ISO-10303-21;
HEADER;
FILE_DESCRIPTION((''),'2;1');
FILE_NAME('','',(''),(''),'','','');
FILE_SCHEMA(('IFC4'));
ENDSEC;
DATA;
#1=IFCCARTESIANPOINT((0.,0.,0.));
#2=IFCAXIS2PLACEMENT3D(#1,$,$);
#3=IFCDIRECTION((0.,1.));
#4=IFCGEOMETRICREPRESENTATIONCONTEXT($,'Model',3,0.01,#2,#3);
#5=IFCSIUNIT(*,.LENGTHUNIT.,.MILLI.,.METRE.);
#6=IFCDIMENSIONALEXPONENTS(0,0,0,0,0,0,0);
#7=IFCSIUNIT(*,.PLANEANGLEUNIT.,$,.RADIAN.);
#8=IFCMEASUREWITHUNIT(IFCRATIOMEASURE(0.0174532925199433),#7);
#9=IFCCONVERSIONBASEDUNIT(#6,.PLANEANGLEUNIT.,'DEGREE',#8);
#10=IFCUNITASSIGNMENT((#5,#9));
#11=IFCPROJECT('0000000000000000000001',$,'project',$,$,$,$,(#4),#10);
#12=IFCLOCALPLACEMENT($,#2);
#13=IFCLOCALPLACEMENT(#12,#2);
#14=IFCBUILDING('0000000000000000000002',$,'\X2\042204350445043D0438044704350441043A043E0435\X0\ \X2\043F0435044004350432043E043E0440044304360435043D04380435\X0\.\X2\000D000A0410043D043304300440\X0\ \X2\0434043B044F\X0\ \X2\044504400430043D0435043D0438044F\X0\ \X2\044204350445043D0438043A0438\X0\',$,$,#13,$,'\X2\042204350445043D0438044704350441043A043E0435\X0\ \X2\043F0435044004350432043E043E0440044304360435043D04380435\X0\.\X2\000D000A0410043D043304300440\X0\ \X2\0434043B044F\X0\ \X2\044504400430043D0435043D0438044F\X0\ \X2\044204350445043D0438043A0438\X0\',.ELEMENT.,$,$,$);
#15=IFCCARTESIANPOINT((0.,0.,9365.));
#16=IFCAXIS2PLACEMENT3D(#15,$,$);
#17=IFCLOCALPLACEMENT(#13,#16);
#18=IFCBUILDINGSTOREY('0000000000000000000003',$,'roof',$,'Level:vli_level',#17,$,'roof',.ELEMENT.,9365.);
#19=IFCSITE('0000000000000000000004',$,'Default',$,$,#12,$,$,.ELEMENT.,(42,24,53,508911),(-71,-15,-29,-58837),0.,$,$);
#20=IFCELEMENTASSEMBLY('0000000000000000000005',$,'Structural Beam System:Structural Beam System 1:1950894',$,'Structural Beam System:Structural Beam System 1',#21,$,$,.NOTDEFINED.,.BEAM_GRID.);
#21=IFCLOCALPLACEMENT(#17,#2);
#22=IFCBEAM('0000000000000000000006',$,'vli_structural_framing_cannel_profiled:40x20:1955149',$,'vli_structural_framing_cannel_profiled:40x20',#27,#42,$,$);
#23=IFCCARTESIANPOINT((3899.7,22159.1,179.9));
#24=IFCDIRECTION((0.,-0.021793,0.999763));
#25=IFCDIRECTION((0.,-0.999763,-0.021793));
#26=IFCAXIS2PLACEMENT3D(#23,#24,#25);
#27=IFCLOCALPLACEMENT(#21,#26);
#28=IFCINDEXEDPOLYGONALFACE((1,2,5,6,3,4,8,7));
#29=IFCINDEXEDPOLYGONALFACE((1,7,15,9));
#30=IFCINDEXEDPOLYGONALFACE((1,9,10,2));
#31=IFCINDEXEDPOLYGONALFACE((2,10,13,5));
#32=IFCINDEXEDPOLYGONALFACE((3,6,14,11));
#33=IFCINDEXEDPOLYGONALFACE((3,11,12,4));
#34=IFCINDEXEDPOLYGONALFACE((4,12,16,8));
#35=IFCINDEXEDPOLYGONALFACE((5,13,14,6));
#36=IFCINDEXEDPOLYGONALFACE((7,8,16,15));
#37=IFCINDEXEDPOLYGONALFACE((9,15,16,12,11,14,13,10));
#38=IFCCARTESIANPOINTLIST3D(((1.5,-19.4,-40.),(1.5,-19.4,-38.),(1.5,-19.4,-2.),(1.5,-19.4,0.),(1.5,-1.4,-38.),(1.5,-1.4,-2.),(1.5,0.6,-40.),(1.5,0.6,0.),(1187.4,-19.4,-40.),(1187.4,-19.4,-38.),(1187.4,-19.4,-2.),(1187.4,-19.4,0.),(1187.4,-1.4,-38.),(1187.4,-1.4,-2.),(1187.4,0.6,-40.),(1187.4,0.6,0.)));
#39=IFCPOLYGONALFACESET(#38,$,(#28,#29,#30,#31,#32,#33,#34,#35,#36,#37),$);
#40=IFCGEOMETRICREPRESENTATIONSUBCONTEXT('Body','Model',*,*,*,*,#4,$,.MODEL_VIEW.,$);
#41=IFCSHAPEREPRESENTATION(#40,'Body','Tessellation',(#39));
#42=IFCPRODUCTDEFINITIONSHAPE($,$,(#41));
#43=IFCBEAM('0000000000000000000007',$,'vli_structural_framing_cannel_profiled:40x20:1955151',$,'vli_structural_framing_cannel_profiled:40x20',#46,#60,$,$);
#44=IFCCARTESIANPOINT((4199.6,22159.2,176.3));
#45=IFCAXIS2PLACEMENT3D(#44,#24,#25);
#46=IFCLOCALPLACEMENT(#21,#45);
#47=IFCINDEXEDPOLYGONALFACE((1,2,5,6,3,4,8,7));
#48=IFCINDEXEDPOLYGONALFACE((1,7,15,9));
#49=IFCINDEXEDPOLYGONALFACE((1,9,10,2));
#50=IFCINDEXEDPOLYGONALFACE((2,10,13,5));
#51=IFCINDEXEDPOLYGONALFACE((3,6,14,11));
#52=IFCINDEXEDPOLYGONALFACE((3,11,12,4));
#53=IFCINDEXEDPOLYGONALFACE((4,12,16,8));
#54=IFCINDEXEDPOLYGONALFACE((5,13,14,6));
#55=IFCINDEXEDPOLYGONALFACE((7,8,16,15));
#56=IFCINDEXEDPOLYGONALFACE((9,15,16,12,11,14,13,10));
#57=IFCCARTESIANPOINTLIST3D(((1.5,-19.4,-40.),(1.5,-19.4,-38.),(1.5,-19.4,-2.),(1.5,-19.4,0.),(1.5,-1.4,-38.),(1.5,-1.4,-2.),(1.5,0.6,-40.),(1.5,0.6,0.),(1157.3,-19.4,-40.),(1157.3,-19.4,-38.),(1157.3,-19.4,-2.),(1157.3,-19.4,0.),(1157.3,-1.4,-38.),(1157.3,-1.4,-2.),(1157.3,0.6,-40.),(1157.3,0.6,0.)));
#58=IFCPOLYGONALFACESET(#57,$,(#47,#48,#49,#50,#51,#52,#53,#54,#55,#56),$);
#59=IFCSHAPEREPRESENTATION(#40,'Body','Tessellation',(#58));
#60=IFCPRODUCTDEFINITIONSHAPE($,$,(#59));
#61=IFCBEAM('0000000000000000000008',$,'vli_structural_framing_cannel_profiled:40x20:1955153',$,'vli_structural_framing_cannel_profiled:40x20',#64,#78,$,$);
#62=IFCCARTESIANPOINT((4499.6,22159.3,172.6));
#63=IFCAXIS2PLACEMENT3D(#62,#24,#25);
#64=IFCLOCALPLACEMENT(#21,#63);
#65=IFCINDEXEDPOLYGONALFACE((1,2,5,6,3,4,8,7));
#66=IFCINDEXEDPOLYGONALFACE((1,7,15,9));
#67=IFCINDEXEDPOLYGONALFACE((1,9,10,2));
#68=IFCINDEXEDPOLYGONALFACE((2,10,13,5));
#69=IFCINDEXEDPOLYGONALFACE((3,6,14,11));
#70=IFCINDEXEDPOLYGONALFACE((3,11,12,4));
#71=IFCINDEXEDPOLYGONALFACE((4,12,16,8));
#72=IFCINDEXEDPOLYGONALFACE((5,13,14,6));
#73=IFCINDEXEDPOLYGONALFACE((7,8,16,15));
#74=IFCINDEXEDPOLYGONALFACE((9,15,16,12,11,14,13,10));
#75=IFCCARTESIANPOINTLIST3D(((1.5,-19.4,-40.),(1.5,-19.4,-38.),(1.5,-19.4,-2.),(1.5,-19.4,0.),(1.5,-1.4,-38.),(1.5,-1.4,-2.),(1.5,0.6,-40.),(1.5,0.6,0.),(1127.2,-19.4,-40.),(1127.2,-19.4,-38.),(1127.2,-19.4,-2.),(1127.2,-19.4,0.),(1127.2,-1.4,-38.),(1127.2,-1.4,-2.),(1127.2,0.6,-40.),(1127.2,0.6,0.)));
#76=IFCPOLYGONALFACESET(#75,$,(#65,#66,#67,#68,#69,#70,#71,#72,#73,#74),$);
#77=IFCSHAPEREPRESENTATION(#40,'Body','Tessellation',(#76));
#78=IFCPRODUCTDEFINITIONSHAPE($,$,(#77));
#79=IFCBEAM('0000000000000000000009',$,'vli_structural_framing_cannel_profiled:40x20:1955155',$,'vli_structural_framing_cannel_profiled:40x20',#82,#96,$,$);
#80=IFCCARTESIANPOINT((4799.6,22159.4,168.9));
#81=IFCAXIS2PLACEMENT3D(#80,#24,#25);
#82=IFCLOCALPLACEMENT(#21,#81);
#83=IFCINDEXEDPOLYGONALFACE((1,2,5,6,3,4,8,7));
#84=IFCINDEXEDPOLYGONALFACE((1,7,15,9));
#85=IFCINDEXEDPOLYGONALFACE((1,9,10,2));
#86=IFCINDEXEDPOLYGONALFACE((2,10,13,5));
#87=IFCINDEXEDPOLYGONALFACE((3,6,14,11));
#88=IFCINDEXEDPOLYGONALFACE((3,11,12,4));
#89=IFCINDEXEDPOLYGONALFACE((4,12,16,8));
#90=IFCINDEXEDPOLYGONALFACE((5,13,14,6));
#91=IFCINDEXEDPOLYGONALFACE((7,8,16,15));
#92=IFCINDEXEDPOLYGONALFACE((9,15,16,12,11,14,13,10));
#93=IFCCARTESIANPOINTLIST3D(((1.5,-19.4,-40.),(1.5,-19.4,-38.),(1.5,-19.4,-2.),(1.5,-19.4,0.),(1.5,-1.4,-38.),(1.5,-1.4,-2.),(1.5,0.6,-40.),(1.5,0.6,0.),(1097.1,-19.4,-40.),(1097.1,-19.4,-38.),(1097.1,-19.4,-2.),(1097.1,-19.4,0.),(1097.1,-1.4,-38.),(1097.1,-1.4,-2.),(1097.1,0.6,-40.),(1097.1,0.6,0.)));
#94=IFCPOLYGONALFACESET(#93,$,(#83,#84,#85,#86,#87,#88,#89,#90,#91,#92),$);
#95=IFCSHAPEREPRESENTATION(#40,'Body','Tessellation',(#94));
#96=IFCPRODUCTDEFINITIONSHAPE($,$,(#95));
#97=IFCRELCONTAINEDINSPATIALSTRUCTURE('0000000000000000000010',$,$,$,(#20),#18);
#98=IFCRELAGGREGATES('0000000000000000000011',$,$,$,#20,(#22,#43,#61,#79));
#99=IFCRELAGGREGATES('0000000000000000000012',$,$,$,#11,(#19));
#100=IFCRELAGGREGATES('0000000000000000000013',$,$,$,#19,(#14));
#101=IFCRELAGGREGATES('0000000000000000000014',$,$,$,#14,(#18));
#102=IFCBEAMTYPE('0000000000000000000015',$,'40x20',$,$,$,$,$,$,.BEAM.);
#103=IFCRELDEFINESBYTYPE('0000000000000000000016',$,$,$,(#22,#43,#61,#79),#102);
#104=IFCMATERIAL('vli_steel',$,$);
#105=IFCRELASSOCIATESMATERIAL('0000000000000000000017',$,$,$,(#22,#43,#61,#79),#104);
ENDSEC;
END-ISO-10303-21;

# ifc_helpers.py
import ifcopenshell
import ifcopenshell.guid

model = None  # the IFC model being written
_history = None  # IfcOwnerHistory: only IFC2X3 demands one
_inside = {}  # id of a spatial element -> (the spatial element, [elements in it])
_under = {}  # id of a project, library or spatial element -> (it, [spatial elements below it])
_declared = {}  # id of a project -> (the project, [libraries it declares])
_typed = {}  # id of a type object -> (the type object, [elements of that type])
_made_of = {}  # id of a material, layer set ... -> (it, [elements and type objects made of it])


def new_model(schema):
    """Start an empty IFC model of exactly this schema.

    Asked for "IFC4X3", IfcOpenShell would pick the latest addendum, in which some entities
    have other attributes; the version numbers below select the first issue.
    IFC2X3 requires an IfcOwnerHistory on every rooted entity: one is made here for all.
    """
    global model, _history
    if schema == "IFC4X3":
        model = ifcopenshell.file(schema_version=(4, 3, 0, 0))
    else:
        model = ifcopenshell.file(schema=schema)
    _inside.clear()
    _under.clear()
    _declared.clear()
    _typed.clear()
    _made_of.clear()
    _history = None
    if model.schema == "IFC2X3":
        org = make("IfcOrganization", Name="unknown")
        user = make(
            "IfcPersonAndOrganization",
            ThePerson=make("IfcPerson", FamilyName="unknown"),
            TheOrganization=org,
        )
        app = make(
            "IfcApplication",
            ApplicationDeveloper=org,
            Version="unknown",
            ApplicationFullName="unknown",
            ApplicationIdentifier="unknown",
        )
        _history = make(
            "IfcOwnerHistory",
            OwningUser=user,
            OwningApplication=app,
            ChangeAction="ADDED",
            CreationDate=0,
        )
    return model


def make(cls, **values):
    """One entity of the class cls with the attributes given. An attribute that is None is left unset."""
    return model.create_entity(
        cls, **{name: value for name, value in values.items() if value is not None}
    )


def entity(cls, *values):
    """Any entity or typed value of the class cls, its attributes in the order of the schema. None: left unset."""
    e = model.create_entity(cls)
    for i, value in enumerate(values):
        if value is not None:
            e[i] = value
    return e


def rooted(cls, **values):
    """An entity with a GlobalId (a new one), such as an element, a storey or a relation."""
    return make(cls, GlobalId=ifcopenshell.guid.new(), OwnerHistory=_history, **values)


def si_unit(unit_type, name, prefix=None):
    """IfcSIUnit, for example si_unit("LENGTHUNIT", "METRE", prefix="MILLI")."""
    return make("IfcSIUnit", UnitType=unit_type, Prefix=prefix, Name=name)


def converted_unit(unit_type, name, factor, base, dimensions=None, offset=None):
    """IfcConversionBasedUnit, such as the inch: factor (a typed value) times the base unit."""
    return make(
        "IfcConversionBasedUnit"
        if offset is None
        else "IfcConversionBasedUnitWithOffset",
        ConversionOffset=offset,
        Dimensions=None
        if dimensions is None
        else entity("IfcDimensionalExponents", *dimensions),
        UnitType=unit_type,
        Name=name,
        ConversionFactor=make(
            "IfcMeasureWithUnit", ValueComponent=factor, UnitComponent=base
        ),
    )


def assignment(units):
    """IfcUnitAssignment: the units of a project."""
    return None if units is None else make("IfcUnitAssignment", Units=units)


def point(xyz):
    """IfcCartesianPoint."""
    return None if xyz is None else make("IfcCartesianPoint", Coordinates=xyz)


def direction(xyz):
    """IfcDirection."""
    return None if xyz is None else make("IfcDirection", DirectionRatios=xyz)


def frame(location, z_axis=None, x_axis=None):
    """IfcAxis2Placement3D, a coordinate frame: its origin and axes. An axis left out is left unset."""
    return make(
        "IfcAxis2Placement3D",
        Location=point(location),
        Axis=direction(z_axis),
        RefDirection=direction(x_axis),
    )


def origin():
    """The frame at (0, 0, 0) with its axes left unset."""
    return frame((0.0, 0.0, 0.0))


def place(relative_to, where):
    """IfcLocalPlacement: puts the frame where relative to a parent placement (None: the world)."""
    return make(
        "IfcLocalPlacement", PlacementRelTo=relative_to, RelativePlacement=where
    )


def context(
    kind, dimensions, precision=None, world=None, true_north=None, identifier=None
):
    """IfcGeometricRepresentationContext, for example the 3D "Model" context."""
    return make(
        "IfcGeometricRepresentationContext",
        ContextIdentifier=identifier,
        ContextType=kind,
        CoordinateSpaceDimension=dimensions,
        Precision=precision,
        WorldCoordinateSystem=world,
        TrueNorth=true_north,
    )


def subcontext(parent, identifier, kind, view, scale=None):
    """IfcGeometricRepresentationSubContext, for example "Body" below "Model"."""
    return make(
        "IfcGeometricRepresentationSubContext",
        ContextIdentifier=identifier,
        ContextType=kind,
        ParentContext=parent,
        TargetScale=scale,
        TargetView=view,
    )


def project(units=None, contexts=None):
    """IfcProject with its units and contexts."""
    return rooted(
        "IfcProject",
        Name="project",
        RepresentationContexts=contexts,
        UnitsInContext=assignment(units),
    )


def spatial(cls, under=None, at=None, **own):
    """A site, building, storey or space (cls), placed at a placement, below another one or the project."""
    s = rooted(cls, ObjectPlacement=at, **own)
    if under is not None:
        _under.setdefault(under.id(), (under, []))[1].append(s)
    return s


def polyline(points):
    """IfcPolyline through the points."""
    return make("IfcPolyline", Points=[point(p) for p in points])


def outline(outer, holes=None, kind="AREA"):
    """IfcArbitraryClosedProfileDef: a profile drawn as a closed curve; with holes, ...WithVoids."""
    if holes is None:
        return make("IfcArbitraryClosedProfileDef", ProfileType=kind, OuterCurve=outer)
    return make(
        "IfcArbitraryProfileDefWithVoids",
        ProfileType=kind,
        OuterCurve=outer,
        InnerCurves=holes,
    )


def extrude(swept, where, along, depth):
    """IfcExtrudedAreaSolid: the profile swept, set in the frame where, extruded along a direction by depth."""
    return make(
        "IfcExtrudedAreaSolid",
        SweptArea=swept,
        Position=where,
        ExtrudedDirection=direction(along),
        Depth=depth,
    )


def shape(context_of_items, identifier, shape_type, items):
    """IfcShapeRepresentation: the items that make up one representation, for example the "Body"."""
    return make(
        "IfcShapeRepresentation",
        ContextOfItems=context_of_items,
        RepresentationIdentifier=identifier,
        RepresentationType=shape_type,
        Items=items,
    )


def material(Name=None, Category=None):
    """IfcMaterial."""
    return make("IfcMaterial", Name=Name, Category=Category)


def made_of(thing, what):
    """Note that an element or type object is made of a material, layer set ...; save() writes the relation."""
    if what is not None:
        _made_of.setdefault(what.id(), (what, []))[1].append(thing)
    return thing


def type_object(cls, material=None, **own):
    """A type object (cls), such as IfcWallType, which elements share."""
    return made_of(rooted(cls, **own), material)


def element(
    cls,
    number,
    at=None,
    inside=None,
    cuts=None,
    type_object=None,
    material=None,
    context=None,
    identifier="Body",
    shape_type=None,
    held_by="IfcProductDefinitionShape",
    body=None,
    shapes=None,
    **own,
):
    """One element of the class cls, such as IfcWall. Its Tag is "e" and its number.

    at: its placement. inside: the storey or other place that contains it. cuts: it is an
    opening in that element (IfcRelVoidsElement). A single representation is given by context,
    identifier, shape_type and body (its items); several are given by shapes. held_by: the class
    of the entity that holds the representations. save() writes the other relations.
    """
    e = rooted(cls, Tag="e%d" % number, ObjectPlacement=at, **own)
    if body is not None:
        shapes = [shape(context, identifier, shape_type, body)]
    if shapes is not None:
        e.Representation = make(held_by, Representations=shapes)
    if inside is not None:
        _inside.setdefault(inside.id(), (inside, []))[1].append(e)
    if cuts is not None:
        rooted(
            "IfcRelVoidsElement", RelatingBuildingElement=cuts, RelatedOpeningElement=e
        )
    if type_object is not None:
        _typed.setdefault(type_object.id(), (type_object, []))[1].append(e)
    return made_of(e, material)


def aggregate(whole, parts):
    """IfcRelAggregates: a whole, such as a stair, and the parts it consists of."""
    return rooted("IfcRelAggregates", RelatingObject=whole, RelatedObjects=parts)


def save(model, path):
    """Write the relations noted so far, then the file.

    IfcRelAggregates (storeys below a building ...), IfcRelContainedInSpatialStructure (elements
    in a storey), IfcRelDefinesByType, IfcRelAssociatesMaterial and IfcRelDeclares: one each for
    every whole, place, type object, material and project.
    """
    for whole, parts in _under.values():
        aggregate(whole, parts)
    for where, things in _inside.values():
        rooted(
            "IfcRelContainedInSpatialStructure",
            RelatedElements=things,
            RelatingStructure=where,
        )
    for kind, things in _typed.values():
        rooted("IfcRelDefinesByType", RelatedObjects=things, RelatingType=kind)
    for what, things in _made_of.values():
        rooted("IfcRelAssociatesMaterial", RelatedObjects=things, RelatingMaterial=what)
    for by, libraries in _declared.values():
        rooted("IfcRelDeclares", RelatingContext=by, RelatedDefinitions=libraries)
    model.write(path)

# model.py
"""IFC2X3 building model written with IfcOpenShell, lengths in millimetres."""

from ifc_helpers import new_model, entity, si_unit, converted_unit, direction, frame, origin, place, context, subcontext, project, spatial, polyline, outline, extrude, material, type_object, element, aggregate, save


model = new_model("IFC2X3")

# Units and contexts
model_context = context("Model", 3, precision=0.01, world=origin(), true_north=direction((0.0, 1.0)))
body_context = subcontext(model_context, "Body", "Model", "MODEL_VIEW")
ifc_project = project(units=[si_unit("LENGTHUNIT", "METRE", prefix="MILLI"), converted_unit("PLANEANGLEUNIT", "DEGREE", entity("IfcRatioMeasure", 0.0174532925199433), si_unit("PLANEANGLEUNIT", "RADIAN"), dimensions=[0, 0, 0, 0, 0, 0, 0])], contexts=[model_context])

# Site, building, storey
site_placement = place(None, origin())
site = spatial("IfcSite", under=ifc_project, at=site_placement, Name="Default", CompositionType="ELEMENT", RefLatitude=(42, 24, 53, 508911), RefLongitude=(-71, -15, -29, -58837), RefElevation=0.0)
building_placement = place(site_placement, origin())
building = spatial("IfcBuilding", under=site, at=building_placement, Name="Техническое перевооружение.\r\nАнгар для хранения техники", LongName="Техническое перевооружение.\r\nАнгар для хранения техники", CompositionType="ELEMENT")
storey_placement = place(building_placement, frame((0.0, 0.0, 9365.0)))
storey = spatial("IfcBuildingStorey", under=building, at=storey_placement, Name="roof", ObjectType="Level:vli_level", LongName="roof", CompositionType="ELEMENT", Elevation=9365.0)

# Element assembly, beams
ifc_material = material(Name="vli_steel")
beam_type = type_object("IfcBeamType", Name="40x20", PredefinedType="BEAM")
assembly_1_placement = place(storey_placement, origin())
assembly_1 = element("IfcElementAssembly", 1, at=assembly_1_placement, inside=storey, Name="Structural Beam System:Structural Beam System 1:1950894", ObjectType="Structural Beam System:Structural Beam System 1", AssemblyPlace="NOTDEFINED", PredefinedType="BEAM_GRID")
beam_1_placement = place(assembly_1_placement, frame((3899.7, 22159.1, 179.9), z_axis=(0.0, -0.021793, 0.999763), x_axis=(0.0, -0.999763, -0.021793)))
beam_1 = element("IfcBeam", 2, at=beam_1_placement, type_object=beam_type, material=ifc_material, Name="vli_structural_framing_cannel_profiled:40x20:1955149", ObjectType="vli_structural_framing_cannel_profiled:40x20", context=body_context, shape_type="SweptSolid", body=[
    extrude(outline(polyline([(-20.0, -9.5), (-18.0, -9.5), (-18.0, 8.5), (18.0, 8.5), (18.0, -9.5), (20.0, -9.5), (20.0, 10.5), (-20.0, 10.5), (-20.0, -9.5)])), frame((1.5, -9.9, -20.0), z_axis=(1.0, 0.0, 0.0), x_axis=(0.0, 0.0, -1.0)), (0.0, 0.0, 1.0), 1185.9),
])
beam_2_placement = place(assembly_1_placement, frame((4199.6, 22159.2, 176.3), z_axis=(0.0, -0.021793, 0.999763), x_axis=(0.0, -0.999763, -0.021793)))
beam_2 = element("IfcBeam", 3, at=beam_2_placement, type_object=beam_type, material=ifc_material, Name="vli_structural_framing_cannel_profiled:40x20:1955151", ObjectType="vli_structural_framing_cannel_profiled:40x20", context=body_context, shape_type="SweptSolid", body=[
    extrude(outline(polyline([(-20.0, -9.5), (-18.0, -9.5), (-18.0, 8.5), (18.0, 8.5), (18.0, -9.5), (20.0, -9.5), (20.0, 10.5), (-20.0, 10.5), (-20.0, -9.5)])), frame((1.5, -9.9, -20.0), z_axis=(1.0, 0.0, 0.0), x_axis=(0.0, 0.0, -1.0)), (0.0, 0.0, 1.0), 1155.8),
])
beam_3_placement = place(assembly_1_placement, frame((4499.6, 22159.3, 172.6), z_axis=(0.0, -0.021793, 0.999763), x_axis=(0.0, -0.999763, -0.021793)))
beam_3 = element("IfcBeam", 4, at=beam_3_placement, type_object=beam_type, material=ifc_material, Name="vli_structural_framing_cannel_profiled:40x20:1955153", ObjectType="vli_structural_framing_cannel_profiled:40x20", context=body_context, shape_type="SweptSolid", body=[
    extrude(outline(polyline([(-20.0, -9.5), (-18.0, -9.5), (-18.0, 8.5), (18.0, 8.5), (18.0, -9.5), (20.0, -9.5), (20.0, 10.5), (-20.0, 10.5), (-20.0, -9.5)])), frame((1.5, -9.9, -20.0), z_axis=(1.0, 0.0, 0.0), x_axis=(0.0, 0.0, -1.0)), (0.0, 0.0, 1.0), 1125.7),
])
beam_4_placement = place(assembly_1_placement, frame((4799.6, 22159.4, 168.9), z_axis=(0.0, -0.021793, 0.999763), x_axis=(0.0, -0.999763, -0.021793)))
beam_4 = element("IfcBeam", 5, at=beam_4_placement, type_object=beam_type, material=ifc_material, Name="vli_structural_framing_cannel_profiled:40x20:1955155", ObjectType="vli_structural_framing_cannel_profiled:40x20", context=body_context, shape_type="SweptSolid", body=[
    extrude(outline(polyline([(-20.0, -9.5), (-18.0, -9.5), (-18.0, 8.5), (18.0, 8.5), (18.0, -9.5), (20.0, -9.5), (20.0, 10.5), (-20.0, 10.5), (-20.0, -9.5)])), frame((1.5, -9.9, -20.0), z_axis=(1.0, 0.0, 0.0), x_axis=(0.0, 0.0, -1.0)), (0.0, 0.0, 1.0), 1095.7),
])
aggregate(assembly_1, [beam_1, beam_2, beam_3, beam_4])

save(model, "model.ifc")
